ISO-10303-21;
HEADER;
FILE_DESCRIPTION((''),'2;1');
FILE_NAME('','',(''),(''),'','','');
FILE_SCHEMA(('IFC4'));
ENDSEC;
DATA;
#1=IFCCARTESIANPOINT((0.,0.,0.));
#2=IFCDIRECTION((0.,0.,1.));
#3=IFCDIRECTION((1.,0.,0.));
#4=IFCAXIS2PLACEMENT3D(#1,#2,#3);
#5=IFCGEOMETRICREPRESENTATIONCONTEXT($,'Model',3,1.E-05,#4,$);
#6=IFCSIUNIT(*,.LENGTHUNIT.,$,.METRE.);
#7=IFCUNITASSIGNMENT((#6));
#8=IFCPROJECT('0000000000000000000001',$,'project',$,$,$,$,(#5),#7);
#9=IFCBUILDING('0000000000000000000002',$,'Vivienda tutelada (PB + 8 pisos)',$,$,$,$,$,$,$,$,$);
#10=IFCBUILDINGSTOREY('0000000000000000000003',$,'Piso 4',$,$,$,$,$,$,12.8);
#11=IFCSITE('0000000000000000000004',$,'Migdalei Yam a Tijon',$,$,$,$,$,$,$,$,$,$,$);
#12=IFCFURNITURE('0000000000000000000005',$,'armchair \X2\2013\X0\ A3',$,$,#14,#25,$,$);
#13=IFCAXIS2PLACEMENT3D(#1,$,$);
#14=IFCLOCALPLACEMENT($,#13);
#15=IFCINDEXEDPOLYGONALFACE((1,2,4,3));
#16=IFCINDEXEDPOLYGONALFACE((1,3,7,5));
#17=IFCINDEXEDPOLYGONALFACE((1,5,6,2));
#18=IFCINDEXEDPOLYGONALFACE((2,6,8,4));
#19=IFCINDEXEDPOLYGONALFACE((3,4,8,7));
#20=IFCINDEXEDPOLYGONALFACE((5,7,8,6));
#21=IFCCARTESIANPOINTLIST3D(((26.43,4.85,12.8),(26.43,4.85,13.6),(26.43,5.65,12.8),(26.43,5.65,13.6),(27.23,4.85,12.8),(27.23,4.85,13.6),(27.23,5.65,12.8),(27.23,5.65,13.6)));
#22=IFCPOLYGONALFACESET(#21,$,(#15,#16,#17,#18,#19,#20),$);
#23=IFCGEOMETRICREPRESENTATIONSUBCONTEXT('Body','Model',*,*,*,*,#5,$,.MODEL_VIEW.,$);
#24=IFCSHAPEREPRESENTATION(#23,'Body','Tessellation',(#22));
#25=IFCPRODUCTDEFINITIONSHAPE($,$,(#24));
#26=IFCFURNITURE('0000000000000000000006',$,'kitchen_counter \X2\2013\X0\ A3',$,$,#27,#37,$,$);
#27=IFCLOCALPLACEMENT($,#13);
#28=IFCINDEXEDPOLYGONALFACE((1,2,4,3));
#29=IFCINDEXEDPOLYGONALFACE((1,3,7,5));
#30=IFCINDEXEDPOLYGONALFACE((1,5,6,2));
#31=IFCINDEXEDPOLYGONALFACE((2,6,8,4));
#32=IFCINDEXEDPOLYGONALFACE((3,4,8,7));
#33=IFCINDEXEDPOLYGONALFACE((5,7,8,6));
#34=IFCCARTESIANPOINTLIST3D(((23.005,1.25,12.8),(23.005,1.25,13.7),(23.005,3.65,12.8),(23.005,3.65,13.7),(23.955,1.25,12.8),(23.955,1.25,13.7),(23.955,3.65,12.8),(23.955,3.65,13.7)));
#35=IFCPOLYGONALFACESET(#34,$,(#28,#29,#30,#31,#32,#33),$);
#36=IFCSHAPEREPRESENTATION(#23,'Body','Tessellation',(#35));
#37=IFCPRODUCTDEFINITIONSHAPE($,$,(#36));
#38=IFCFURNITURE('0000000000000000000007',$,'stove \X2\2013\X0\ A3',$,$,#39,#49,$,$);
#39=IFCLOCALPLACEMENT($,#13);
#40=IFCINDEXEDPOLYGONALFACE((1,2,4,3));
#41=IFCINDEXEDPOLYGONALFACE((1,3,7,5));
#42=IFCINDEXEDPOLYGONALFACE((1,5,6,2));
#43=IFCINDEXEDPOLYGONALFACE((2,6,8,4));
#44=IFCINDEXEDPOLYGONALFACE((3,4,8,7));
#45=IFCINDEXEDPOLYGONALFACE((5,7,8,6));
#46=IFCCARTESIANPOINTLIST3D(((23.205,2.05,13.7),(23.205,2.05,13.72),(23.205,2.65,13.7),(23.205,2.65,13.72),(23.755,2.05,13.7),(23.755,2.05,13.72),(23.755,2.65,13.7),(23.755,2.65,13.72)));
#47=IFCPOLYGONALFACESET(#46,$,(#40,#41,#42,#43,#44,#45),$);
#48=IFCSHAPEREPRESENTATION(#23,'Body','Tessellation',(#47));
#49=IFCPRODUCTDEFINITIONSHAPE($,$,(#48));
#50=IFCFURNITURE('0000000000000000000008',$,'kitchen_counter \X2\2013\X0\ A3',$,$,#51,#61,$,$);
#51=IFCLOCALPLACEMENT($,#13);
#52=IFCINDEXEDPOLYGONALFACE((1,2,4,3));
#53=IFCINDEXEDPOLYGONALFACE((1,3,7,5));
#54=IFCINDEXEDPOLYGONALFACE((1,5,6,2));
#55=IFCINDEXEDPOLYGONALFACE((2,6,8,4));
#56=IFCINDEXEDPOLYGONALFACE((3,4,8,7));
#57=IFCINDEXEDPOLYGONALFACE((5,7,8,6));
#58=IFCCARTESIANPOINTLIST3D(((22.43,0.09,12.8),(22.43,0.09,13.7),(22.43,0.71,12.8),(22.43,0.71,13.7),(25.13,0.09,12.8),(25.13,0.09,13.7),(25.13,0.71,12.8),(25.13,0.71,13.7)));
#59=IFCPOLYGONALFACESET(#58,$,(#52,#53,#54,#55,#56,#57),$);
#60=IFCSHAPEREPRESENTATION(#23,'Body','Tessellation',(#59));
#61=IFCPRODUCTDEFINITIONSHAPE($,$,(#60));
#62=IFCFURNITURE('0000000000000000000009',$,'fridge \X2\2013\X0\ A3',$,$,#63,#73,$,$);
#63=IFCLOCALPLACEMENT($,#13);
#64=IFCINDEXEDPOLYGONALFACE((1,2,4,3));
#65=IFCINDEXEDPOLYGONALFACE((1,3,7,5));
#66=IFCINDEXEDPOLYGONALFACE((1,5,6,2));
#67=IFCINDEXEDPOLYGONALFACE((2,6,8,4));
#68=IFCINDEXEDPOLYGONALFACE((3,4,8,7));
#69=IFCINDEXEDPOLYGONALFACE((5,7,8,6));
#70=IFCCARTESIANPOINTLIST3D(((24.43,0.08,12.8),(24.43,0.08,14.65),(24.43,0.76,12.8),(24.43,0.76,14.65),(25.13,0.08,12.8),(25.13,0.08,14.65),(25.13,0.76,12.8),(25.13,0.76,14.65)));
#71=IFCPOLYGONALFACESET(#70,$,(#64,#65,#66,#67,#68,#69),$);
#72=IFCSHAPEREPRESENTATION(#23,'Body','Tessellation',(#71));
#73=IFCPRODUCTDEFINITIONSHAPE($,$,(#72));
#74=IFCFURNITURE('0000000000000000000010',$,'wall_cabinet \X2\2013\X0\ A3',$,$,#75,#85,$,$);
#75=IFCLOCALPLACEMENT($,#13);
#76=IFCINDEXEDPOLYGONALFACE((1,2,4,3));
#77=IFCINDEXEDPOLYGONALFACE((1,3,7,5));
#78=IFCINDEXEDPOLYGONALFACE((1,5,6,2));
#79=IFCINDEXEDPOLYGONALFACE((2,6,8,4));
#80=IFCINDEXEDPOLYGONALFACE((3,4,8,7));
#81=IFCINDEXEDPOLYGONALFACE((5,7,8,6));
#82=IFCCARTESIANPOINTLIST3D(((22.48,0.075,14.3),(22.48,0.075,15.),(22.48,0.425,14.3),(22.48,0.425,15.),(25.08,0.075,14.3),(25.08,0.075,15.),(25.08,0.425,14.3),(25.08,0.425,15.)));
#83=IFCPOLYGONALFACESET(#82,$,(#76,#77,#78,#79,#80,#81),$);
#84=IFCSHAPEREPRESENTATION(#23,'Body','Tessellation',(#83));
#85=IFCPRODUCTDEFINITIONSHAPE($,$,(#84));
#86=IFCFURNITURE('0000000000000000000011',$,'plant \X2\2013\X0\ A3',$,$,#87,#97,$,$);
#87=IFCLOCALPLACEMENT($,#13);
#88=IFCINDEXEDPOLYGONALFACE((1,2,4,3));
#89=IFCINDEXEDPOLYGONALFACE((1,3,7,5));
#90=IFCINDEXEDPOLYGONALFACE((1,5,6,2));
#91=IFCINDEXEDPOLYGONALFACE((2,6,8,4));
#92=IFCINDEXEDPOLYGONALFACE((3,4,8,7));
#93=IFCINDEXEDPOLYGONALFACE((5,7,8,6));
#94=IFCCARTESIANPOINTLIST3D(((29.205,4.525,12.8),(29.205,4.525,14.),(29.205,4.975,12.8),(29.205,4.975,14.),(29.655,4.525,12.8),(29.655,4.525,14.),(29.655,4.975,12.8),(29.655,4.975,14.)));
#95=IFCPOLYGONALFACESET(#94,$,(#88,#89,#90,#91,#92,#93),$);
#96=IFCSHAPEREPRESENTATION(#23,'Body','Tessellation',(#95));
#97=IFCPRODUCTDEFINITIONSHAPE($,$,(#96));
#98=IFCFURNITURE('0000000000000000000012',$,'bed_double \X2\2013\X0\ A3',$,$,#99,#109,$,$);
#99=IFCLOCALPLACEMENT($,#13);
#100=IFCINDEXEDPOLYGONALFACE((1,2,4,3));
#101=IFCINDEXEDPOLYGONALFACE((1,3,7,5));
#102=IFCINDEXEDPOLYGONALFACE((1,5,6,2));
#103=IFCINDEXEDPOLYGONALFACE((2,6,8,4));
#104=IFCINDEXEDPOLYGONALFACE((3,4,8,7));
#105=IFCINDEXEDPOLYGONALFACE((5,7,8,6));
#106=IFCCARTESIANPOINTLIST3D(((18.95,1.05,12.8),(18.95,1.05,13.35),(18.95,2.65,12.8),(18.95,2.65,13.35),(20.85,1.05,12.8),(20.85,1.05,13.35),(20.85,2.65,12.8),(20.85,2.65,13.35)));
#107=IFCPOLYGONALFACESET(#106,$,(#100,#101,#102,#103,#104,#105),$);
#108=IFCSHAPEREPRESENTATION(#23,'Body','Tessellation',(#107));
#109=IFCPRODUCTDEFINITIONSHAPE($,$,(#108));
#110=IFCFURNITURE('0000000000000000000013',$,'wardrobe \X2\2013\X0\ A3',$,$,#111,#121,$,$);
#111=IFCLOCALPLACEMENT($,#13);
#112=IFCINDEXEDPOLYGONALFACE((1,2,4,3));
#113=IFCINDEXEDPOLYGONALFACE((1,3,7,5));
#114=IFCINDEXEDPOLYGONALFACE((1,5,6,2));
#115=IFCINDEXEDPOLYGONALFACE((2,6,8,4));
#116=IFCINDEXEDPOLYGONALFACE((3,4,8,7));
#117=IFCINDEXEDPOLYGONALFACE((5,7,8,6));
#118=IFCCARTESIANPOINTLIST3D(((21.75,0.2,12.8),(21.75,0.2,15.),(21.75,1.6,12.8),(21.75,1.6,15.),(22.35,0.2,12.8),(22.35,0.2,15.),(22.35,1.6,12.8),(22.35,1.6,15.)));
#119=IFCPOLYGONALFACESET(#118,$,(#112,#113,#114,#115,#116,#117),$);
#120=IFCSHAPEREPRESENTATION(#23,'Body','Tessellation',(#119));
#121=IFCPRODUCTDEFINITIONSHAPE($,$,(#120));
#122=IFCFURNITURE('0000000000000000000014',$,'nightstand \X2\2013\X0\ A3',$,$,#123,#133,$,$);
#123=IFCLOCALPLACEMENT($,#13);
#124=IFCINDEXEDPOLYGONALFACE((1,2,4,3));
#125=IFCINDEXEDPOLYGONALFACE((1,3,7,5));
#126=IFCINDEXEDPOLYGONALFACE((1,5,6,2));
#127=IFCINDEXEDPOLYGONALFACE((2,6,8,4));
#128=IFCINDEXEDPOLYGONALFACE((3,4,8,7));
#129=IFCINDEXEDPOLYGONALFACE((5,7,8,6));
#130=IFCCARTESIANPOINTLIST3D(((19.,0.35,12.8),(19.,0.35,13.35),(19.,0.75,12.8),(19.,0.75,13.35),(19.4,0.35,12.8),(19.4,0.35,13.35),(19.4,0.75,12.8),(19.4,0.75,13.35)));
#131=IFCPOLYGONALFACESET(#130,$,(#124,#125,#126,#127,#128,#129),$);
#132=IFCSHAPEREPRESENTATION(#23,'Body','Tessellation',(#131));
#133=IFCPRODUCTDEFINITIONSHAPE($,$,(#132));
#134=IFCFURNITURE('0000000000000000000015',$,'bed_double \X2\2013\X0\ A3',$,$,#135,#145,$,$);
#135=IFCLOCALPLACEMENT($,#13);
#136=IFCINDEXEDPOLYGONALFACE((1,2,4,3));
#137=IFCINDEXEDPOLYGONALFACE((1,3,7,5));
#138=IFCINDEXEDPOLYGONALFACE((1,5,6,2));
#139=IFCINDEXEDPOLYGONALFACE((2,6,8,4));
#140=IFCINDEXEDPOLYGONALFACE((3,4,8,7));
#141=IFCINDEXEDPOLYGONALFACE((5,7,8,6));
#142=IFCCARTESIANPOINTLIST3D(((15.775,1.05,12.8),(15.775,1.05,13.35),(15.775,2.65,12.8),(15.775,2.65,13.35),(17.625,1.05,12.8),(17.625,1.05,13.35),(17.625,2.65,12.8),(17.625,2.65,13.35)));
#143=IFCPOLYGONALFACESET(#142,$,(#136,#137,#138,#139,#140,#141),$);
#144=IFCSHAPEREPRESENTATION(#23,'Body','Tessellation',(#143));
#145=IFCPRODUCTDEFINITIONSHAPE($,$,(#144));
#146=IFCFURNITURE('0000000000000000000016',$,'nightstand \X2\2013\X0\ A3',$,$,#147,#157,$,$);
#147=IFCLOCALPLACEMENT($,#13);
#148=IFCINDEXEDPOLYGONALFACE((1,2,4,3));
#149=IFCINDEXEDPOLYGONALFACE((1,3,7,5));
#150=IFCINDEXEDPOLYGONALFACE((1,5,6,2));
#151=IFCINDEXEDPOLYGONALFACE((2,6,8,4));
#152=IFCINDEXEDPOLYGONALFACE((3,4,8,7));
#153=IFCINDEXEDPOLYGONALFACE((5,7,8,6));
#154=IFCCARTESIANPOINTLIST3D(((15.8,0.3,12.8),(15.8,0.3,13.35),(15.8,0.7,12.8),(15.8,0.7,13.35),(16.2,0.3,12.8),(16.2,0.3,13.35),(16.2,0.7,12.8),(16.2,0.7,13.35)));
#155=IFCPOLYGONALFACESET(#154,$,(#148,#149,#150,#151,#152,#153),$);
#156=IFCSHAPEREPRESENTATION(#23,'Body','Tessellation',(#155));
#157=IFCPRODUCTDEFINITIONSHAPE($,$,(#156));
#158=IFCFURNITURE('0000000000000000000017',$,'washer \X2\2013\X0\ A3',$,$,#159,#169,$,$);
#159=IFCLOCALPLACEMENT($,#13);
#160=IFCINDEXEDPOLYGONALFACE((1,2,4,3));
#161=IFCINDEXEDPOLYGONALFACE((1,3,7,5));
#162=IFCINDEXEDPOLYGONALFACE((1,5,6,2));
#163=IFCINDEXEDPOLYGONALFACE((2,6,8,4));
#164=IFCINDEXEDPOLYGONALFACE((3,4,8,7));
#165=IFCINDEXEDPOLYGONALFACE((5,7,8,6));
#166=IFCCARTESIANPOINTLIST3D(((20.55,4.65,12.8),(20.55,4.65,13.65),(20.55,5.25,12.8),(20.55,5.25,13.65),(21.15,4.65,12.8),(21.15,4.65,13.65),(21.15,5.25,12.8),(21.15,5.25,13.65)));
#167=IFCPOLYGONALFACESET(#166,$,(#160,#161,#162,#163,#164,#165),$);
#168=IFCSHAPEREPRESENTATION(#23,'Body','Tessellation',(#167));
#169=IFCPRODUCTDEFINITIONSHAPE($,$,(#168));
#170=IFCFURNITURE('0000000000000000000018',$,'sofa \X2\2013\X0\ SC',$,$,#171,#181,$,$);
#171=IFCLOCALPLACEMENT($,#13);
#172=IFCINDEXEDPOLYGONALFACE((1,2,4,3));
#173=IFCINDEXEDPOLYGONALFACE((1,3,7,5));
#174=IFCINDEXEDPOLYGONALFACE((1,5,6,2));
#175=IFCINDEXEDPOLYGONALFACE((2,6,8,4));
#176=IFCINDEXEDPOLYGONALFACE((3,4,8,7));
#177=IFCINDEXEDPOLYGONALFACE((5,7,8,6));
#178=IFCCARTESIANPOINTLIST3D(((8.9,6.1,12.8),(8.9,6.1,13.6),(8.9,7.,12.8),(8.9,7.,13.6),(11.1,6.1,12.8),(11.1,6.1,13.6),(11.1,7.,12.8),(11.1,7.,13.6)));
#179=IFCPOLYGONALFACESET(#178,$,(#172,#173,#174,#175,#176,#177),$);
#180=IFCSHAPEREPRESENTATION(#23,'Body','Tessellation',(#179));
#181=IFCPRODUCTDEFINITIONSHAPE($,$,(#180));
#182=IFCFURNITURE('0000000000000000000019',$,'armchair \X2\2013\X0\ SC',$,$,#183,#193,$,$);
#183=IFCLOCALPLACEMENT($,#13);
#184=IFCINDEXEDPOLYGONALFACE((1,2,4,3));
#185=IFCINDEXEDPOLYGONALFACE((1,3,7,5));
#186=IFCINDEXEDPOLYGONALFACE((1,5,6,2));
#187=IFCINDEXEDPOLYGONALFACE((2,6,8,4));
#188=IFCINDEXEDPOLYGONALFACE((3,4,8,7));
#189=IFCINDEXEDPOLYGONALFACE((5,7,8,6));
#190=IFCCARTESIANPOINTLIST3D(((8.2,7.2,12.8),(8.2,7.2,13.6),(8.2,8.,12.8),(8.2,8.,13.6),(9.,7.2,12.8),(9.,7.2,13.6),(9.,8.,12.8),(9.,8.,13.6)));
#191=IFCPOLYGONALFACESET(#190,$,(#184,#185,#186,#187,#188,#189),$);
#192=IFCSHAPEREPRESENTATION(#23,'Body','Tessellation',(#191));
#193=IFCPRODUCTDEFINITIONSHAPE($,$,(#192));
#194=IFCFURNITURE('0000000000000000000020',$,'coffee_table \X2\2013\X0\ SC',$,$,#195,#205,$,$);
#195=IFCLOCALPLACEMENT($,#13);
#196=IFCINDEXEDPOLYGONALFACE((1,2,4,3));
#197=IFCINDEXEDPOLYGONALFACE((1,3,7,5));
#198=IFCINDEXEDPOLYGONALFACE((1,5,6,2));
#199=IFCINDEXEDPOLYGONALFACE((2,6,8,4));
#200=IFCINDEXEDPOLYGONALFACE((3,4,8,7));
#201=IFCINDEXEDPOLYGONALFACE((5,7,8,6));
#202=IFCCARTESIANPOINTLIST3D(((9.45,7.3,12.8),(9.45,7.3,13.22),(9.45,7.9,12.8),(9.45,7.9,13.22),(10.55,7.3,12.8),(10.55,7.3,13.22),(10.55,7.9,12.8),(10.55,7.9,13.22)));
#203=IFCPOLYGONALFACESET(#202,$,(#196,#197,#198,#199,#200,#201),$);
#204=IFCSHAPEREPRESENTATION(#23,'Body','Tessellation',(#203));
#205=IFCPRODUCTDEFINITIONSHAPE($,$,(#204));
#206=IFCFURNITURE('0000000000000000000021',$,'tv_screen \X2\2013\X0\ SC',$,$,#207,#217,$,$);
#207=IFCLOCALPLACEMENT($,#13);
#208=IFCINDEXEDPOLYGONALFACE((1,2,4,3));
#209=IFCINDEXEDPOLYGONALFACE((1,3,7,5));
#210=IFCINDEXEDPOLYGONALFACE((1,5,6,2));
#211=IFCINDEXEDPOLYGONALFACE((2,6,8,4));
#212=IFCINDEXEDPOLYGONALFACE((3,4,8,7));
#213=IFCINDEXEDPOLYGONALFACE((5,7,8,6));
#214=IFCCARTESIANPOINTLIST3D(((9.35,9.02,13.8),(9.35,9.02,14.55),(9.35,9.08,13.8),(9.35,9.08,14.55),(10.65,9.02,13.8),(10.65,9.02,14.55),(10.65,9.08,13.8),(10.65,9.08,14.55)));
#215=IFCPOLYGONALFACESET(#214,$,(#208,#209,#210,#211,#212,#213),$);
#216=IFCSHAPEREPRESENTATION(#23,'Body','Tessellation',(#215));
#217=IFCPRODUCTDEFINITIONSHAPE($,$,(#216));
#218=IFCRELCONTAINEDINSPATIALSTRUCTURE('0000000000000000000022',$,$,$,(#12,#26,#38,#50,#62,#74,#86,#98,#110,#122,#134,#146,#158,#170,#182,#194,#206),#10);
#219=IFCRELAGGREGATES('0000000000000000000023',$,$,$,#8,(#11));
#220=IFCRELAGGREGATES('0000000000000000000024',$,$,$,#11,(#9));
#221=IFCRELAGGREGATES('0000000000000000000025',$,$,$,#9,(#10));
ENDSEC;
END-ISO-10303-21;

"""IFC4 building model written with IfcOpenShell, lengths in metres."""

from ifc_helpers import new_model, si_unit, frame, origin_with_axes, context, subcontext, project, spatial, line, indexed_curve, outline, extrude, element, save


model = new_model("IFC4")

# Units and contexts
model_context = context("Model", 3, precision=1e-05, world=origin_with_axes())
body_context = subcontext(model_context, "Body", "Model", "MODEL_VIEW")
ifc_project = project(units=[si_unit("LENGTHUNIT", "METRE")], contexts=[model_context])

# Site, building, storey
site = spatial("IfcSite", under=ifc_project, Name="Migdalei Yam a Tijon")
building = spatial("IfcBuilding", under=site, Name="Vivienda tutelada (PB + 8 pisos)")
storey = spatial("IfcBuildingStorey", under=building, Name="Piso 4", Elevation=12.8)

# Furniture
element("IfcFurniture", 1, inside=storey, Name="armchair – A3", context=body_context, shape_type="SweptSolid", body=[
    extrude(outline(indexed_curve([(0.0, 0.0), (0.8, 0.0), (0.8, 0.8), (0.0, 0.8)], segments=[line(1, 2, 3, 4, 1)])), frame((26.43, 4.85, 12.8), z_axis=(0.0, 0.0, 1.0), x_axis=(1.0, 0.0, 0.0)), (0.0, 0.0, 1.0), 0.8),
])
element("IfcFurniture", 2, inside=storey, Name="kitchen_counter – A3", context=body_context, shape_type="SweptSolid", body=[
    extrude(outline(indexed_curve([(0.0, 0.0), (0.95, 0.0), (0.95, 2.4), (0.0, 2.4)], segments=[line(1, 2, 3, 4, 1)])), frame((23.005, 1.25, 12.8), z_axis=(0.0, 0.0, 1.0), x_axis=(1.0, 0.0, 0.0)), (0.0, 0.0, 1.0), 0.9),
])
element("IfcFurniture", 3, inside=storey, Name="stove – A3", context=body_context, shape_type="SweptSolid", body=[
    extrude(outline(indexed_curve([(0.0, 0.0), (0.55, 0.0), (0.55, 0.6), (0.0, 0.6)], segments=[line(1, 2, 3, 4, 1)])), frame((23.205, 2.05, 13.7), z_axis=(0.0, 0.0, 1.0), x_axis=(1.0, 0.0, 0.0)), (0.0, 0.0, 1.0), 0.02),
])
element("IfcFurniture", 4, inside=storey, Name="kitchen_counter – A3", context=body_context, shape_type="SweptSolid", body=[
    extrude(outline(indexed_curve([(0.0, 0.0), (2.7, 0.0), (2.7, 0.62), (0.0, 0.62)], segments=[line(1, 2, 3, 4, 1)])), frame((22.43, 0.09, 12.8), z_axis=(0.0, 0.0, 1.0), x_axis=(1.0, 0.0, 0.0)), (0.0, 0.0, 1.0), 0.9),
])
element("IfcFurniture", 5, inside=storey, Name="fridge – A3", context=body_context, shape_type="SweptSolid", body=[
    extrude(outline(indexed_curve([(0.0, 0.0), (0.7, 0.0), (0.7, 0.68), (0.0, 0.68)], segments=[line(1, 2, 3, 4, 1)])), frame((24.43, 0.08, 12.8), z_axis=(0.0, 0.0, 1.0), x_axis=(1.0, 0.0, 0.0)), (0.0, 0.0, 1.0), 1.85),
])
element("IfcFurniture", 6, inside=storey, Name="wall_cabinet – A3", context=body_context, shape_type="SweptSolid", body=[
    extrude(outline(indexed_curve([(0.0, 0.0), (2.6, 0.0), (2.6, 0.35), (0.0, 0.35)], segments=[line(1, 2, 3, 4, 1)])), frame((22.48, 0.075, 14.3), z_axis=(0.0, 0.0, 1.0), x_axis=(1.0, 0.0, 0.0)), (0.0, 0.0, 1.0), 0.7),
])
element("IfcFurniture", 7, inside=storey, Name="plant – A3", context=body_context, shape_type="SweptSolid", body=[
    extrude(outline(indexed_curve([(0.0, 0.0), (0.45, 0.0), (0.45, 0.45), (0.0, 0.45)], segments=[line(1, 2, 3, 4, 1)])), frame((29.205, 4.525, 12.8), z_axis=(0.0, 0.0, 1.0), x_axis=(1.0, 0.0, 0.0)), (0.0, 0.0, 1.0), 1.2),
])
element("IfcFurniture", 8, inside=storey, Name="bed_double – A3", context=body_context, shape_type="SweptSolid", body=[
    extrude(outline(indexed_curve([(0.0, 0.0), (1.9, 0.0), (1.9, 1.6), (0.0, 1.6)], segments=[line(1, 2, 3, 4, 1)])), frame((18.95, 1.05, 12.8), z_axis=(0.0, 0.0, 1.0), x_axis=(1.0, 0.0, 0.0)), (0.0, 0.0, 1.0), 0.55),
])
element("IfcFurniture", 9, inside=storey, Name="wardrobe – A3", context=body_context, shape_type="SweptSolid", body=[
    extrude(outline(indexed_curve([(0.0, 0.0), (0.6, 0.0), (0.6, 1.4), (0.0, 1.4)], segments=[line(1, 2, 3, 4, 1)])), frame((21.75, 0.2, 12.8), z_axis=(0.0, 0.0, 1.0), x_axis=(1.0, 0.0, 0.0)), (0.0, 0.0, 1.0), 2.2),
])
element("IfcFurniture", 10, inside=storey, Name="nightstand – A3", context=body_context, shape_type="SweptSolid", body=[
    extrude(outline(indexed_curve([(0.0, 0.0), (0.4, 0.0), (0.4, 0.4), (0.0, 0.4)], segments=[line(1, 2, 3, 4, 1)])), frame((19.0, 0.35, 12.8), z_axis=(0.0, 0.0, 1.0), x_axis=(1.0, 0.0, 0.0)), (0.0, 0.0, 1.0), 0.55),
])
element("IfcFurniture", 11, inside=storey, Name="bed_double – A3", context=body_context, shape_type="SweptSolid", body=[
    extrude(outline(indexed_curve([(0.0, 0.0), (1.85, 0.0), (1.85, 1.6), (0.0, 1.6)], segments=[line(1, 2, 3, 4, 1)])), frame((15.775, 1.05, 12.8), z_axis=(0.0, 0.0, 1.0), x_axis=(1.0, 0.0, 0.0)), (0.0, 0.0, 1.0), 0.55),
])
element("IfcFurniture", 12, inside=storey, Name="nightstand – A3", context=body_context, shape_type="SweptSolid", body=[
    extrude(outline(indexed_curve([(0.0, 0.0), (0.4, 0.0), (0.4, 0.4), (0.0, 0.4)], segments=[line(1, 2, 3, 4, 1)])), frame((15.8, 0.3, 12.8), z_axis=(0.0, 0.0, 1.0), x_axis=(1.0, 0.0, 0.0)), (0.0, 0.0, 1.0), 0.55),
])
element("IfcFurniture", 13, inside=storey, Name="washer – A3", context=body_context, shape_type="SweptSolid", body=[
    extrude(outline(indexed_curve([(0.0, 0.0), (0.6, 0.0), (0.6, 0.6), (0.0, 0.6)], segments=[line(1, 2, 3, 4, 1)])), frame((20.55, 4.65, 12.8), z_axis=(0.0, 0.0, 1.0), x_axis=(1.0, 0.0, 0.0)), (0.0, 0.0, 1.0), 0.85),
])
element("IfcFurniture", 14, inside=storey, Name="sofa – SC", context=body_context, shape_type="SweptSolid", body=[
    extrude(outline(indexed_curve([(0.0, 0.0), (2.2, 0.0), (2.2, 0.9), (0.0, 0.9)], segments=[line(1, 2, 3, 4, 1)])), frame((8.9, 6.1, 12.8), z_axis=(0.0, 0.0, 1.0), x_axis=(1.0, 0.0, 0.0)), (0.0, 0.0, 1.0), 0.8),
])
element("IfcFurniture", 15, inside=storey, Name="armchair – SC", context=body_context, shape_type="SweptSolid", body=[
    extrude(outline(indexed_curve([(0.0, 0.0), (0.8, 0.0), (0.8, 0.8), (0.0, 0.8)], segments=[line(1, 2, 3, 4, 1)])), frame((8.2, 7.2, 12.8), z_axis=(0.0, 0.0, 1.0), x_axis=(1.0, 0.0, 0.0)), (0.0, 0.0, 1.0), 0.8),
])
element("IfcFurniture", 16, inside=storey, Name="coffee_table – SC", context=body_context, shape_type="SweptSolid", body=[
    extrude(outline(indexed_curve([(0.0, 0.0), (1.1, 0.0), (1.1, 0.6), (0.0, 0.6)], segments=[line(1, 2, 3, 4, 1)])), frame((9.45, 7.3, 12.8), z_axis=(0.0, 0.0, 1.0), x_axis=(1.0, 0.0, 0.0)), (0.0, 0.0, 1.0), 0.42),
])
element("IfcFurniture", 17, inside=storey, Name="tv_screen – SC", context=body_context, shape_type="SweptSolid", body=[
    extrude(outline(indexed_curve([(0.0, 0.0), (1.3, 0.0), (1.3, 0.06), (0.0, 0.06)], segments=[line(1, 2, 3, 4, 1)])), frame((9.35, 9.02, 13.8), z_axis=(0.0, 0.0, 1.0), x_axis=(1.0, 0.0, 0.0)), (0.0, 0.0, 1.0), 0.75),
])

save(model, "model.ifc")
